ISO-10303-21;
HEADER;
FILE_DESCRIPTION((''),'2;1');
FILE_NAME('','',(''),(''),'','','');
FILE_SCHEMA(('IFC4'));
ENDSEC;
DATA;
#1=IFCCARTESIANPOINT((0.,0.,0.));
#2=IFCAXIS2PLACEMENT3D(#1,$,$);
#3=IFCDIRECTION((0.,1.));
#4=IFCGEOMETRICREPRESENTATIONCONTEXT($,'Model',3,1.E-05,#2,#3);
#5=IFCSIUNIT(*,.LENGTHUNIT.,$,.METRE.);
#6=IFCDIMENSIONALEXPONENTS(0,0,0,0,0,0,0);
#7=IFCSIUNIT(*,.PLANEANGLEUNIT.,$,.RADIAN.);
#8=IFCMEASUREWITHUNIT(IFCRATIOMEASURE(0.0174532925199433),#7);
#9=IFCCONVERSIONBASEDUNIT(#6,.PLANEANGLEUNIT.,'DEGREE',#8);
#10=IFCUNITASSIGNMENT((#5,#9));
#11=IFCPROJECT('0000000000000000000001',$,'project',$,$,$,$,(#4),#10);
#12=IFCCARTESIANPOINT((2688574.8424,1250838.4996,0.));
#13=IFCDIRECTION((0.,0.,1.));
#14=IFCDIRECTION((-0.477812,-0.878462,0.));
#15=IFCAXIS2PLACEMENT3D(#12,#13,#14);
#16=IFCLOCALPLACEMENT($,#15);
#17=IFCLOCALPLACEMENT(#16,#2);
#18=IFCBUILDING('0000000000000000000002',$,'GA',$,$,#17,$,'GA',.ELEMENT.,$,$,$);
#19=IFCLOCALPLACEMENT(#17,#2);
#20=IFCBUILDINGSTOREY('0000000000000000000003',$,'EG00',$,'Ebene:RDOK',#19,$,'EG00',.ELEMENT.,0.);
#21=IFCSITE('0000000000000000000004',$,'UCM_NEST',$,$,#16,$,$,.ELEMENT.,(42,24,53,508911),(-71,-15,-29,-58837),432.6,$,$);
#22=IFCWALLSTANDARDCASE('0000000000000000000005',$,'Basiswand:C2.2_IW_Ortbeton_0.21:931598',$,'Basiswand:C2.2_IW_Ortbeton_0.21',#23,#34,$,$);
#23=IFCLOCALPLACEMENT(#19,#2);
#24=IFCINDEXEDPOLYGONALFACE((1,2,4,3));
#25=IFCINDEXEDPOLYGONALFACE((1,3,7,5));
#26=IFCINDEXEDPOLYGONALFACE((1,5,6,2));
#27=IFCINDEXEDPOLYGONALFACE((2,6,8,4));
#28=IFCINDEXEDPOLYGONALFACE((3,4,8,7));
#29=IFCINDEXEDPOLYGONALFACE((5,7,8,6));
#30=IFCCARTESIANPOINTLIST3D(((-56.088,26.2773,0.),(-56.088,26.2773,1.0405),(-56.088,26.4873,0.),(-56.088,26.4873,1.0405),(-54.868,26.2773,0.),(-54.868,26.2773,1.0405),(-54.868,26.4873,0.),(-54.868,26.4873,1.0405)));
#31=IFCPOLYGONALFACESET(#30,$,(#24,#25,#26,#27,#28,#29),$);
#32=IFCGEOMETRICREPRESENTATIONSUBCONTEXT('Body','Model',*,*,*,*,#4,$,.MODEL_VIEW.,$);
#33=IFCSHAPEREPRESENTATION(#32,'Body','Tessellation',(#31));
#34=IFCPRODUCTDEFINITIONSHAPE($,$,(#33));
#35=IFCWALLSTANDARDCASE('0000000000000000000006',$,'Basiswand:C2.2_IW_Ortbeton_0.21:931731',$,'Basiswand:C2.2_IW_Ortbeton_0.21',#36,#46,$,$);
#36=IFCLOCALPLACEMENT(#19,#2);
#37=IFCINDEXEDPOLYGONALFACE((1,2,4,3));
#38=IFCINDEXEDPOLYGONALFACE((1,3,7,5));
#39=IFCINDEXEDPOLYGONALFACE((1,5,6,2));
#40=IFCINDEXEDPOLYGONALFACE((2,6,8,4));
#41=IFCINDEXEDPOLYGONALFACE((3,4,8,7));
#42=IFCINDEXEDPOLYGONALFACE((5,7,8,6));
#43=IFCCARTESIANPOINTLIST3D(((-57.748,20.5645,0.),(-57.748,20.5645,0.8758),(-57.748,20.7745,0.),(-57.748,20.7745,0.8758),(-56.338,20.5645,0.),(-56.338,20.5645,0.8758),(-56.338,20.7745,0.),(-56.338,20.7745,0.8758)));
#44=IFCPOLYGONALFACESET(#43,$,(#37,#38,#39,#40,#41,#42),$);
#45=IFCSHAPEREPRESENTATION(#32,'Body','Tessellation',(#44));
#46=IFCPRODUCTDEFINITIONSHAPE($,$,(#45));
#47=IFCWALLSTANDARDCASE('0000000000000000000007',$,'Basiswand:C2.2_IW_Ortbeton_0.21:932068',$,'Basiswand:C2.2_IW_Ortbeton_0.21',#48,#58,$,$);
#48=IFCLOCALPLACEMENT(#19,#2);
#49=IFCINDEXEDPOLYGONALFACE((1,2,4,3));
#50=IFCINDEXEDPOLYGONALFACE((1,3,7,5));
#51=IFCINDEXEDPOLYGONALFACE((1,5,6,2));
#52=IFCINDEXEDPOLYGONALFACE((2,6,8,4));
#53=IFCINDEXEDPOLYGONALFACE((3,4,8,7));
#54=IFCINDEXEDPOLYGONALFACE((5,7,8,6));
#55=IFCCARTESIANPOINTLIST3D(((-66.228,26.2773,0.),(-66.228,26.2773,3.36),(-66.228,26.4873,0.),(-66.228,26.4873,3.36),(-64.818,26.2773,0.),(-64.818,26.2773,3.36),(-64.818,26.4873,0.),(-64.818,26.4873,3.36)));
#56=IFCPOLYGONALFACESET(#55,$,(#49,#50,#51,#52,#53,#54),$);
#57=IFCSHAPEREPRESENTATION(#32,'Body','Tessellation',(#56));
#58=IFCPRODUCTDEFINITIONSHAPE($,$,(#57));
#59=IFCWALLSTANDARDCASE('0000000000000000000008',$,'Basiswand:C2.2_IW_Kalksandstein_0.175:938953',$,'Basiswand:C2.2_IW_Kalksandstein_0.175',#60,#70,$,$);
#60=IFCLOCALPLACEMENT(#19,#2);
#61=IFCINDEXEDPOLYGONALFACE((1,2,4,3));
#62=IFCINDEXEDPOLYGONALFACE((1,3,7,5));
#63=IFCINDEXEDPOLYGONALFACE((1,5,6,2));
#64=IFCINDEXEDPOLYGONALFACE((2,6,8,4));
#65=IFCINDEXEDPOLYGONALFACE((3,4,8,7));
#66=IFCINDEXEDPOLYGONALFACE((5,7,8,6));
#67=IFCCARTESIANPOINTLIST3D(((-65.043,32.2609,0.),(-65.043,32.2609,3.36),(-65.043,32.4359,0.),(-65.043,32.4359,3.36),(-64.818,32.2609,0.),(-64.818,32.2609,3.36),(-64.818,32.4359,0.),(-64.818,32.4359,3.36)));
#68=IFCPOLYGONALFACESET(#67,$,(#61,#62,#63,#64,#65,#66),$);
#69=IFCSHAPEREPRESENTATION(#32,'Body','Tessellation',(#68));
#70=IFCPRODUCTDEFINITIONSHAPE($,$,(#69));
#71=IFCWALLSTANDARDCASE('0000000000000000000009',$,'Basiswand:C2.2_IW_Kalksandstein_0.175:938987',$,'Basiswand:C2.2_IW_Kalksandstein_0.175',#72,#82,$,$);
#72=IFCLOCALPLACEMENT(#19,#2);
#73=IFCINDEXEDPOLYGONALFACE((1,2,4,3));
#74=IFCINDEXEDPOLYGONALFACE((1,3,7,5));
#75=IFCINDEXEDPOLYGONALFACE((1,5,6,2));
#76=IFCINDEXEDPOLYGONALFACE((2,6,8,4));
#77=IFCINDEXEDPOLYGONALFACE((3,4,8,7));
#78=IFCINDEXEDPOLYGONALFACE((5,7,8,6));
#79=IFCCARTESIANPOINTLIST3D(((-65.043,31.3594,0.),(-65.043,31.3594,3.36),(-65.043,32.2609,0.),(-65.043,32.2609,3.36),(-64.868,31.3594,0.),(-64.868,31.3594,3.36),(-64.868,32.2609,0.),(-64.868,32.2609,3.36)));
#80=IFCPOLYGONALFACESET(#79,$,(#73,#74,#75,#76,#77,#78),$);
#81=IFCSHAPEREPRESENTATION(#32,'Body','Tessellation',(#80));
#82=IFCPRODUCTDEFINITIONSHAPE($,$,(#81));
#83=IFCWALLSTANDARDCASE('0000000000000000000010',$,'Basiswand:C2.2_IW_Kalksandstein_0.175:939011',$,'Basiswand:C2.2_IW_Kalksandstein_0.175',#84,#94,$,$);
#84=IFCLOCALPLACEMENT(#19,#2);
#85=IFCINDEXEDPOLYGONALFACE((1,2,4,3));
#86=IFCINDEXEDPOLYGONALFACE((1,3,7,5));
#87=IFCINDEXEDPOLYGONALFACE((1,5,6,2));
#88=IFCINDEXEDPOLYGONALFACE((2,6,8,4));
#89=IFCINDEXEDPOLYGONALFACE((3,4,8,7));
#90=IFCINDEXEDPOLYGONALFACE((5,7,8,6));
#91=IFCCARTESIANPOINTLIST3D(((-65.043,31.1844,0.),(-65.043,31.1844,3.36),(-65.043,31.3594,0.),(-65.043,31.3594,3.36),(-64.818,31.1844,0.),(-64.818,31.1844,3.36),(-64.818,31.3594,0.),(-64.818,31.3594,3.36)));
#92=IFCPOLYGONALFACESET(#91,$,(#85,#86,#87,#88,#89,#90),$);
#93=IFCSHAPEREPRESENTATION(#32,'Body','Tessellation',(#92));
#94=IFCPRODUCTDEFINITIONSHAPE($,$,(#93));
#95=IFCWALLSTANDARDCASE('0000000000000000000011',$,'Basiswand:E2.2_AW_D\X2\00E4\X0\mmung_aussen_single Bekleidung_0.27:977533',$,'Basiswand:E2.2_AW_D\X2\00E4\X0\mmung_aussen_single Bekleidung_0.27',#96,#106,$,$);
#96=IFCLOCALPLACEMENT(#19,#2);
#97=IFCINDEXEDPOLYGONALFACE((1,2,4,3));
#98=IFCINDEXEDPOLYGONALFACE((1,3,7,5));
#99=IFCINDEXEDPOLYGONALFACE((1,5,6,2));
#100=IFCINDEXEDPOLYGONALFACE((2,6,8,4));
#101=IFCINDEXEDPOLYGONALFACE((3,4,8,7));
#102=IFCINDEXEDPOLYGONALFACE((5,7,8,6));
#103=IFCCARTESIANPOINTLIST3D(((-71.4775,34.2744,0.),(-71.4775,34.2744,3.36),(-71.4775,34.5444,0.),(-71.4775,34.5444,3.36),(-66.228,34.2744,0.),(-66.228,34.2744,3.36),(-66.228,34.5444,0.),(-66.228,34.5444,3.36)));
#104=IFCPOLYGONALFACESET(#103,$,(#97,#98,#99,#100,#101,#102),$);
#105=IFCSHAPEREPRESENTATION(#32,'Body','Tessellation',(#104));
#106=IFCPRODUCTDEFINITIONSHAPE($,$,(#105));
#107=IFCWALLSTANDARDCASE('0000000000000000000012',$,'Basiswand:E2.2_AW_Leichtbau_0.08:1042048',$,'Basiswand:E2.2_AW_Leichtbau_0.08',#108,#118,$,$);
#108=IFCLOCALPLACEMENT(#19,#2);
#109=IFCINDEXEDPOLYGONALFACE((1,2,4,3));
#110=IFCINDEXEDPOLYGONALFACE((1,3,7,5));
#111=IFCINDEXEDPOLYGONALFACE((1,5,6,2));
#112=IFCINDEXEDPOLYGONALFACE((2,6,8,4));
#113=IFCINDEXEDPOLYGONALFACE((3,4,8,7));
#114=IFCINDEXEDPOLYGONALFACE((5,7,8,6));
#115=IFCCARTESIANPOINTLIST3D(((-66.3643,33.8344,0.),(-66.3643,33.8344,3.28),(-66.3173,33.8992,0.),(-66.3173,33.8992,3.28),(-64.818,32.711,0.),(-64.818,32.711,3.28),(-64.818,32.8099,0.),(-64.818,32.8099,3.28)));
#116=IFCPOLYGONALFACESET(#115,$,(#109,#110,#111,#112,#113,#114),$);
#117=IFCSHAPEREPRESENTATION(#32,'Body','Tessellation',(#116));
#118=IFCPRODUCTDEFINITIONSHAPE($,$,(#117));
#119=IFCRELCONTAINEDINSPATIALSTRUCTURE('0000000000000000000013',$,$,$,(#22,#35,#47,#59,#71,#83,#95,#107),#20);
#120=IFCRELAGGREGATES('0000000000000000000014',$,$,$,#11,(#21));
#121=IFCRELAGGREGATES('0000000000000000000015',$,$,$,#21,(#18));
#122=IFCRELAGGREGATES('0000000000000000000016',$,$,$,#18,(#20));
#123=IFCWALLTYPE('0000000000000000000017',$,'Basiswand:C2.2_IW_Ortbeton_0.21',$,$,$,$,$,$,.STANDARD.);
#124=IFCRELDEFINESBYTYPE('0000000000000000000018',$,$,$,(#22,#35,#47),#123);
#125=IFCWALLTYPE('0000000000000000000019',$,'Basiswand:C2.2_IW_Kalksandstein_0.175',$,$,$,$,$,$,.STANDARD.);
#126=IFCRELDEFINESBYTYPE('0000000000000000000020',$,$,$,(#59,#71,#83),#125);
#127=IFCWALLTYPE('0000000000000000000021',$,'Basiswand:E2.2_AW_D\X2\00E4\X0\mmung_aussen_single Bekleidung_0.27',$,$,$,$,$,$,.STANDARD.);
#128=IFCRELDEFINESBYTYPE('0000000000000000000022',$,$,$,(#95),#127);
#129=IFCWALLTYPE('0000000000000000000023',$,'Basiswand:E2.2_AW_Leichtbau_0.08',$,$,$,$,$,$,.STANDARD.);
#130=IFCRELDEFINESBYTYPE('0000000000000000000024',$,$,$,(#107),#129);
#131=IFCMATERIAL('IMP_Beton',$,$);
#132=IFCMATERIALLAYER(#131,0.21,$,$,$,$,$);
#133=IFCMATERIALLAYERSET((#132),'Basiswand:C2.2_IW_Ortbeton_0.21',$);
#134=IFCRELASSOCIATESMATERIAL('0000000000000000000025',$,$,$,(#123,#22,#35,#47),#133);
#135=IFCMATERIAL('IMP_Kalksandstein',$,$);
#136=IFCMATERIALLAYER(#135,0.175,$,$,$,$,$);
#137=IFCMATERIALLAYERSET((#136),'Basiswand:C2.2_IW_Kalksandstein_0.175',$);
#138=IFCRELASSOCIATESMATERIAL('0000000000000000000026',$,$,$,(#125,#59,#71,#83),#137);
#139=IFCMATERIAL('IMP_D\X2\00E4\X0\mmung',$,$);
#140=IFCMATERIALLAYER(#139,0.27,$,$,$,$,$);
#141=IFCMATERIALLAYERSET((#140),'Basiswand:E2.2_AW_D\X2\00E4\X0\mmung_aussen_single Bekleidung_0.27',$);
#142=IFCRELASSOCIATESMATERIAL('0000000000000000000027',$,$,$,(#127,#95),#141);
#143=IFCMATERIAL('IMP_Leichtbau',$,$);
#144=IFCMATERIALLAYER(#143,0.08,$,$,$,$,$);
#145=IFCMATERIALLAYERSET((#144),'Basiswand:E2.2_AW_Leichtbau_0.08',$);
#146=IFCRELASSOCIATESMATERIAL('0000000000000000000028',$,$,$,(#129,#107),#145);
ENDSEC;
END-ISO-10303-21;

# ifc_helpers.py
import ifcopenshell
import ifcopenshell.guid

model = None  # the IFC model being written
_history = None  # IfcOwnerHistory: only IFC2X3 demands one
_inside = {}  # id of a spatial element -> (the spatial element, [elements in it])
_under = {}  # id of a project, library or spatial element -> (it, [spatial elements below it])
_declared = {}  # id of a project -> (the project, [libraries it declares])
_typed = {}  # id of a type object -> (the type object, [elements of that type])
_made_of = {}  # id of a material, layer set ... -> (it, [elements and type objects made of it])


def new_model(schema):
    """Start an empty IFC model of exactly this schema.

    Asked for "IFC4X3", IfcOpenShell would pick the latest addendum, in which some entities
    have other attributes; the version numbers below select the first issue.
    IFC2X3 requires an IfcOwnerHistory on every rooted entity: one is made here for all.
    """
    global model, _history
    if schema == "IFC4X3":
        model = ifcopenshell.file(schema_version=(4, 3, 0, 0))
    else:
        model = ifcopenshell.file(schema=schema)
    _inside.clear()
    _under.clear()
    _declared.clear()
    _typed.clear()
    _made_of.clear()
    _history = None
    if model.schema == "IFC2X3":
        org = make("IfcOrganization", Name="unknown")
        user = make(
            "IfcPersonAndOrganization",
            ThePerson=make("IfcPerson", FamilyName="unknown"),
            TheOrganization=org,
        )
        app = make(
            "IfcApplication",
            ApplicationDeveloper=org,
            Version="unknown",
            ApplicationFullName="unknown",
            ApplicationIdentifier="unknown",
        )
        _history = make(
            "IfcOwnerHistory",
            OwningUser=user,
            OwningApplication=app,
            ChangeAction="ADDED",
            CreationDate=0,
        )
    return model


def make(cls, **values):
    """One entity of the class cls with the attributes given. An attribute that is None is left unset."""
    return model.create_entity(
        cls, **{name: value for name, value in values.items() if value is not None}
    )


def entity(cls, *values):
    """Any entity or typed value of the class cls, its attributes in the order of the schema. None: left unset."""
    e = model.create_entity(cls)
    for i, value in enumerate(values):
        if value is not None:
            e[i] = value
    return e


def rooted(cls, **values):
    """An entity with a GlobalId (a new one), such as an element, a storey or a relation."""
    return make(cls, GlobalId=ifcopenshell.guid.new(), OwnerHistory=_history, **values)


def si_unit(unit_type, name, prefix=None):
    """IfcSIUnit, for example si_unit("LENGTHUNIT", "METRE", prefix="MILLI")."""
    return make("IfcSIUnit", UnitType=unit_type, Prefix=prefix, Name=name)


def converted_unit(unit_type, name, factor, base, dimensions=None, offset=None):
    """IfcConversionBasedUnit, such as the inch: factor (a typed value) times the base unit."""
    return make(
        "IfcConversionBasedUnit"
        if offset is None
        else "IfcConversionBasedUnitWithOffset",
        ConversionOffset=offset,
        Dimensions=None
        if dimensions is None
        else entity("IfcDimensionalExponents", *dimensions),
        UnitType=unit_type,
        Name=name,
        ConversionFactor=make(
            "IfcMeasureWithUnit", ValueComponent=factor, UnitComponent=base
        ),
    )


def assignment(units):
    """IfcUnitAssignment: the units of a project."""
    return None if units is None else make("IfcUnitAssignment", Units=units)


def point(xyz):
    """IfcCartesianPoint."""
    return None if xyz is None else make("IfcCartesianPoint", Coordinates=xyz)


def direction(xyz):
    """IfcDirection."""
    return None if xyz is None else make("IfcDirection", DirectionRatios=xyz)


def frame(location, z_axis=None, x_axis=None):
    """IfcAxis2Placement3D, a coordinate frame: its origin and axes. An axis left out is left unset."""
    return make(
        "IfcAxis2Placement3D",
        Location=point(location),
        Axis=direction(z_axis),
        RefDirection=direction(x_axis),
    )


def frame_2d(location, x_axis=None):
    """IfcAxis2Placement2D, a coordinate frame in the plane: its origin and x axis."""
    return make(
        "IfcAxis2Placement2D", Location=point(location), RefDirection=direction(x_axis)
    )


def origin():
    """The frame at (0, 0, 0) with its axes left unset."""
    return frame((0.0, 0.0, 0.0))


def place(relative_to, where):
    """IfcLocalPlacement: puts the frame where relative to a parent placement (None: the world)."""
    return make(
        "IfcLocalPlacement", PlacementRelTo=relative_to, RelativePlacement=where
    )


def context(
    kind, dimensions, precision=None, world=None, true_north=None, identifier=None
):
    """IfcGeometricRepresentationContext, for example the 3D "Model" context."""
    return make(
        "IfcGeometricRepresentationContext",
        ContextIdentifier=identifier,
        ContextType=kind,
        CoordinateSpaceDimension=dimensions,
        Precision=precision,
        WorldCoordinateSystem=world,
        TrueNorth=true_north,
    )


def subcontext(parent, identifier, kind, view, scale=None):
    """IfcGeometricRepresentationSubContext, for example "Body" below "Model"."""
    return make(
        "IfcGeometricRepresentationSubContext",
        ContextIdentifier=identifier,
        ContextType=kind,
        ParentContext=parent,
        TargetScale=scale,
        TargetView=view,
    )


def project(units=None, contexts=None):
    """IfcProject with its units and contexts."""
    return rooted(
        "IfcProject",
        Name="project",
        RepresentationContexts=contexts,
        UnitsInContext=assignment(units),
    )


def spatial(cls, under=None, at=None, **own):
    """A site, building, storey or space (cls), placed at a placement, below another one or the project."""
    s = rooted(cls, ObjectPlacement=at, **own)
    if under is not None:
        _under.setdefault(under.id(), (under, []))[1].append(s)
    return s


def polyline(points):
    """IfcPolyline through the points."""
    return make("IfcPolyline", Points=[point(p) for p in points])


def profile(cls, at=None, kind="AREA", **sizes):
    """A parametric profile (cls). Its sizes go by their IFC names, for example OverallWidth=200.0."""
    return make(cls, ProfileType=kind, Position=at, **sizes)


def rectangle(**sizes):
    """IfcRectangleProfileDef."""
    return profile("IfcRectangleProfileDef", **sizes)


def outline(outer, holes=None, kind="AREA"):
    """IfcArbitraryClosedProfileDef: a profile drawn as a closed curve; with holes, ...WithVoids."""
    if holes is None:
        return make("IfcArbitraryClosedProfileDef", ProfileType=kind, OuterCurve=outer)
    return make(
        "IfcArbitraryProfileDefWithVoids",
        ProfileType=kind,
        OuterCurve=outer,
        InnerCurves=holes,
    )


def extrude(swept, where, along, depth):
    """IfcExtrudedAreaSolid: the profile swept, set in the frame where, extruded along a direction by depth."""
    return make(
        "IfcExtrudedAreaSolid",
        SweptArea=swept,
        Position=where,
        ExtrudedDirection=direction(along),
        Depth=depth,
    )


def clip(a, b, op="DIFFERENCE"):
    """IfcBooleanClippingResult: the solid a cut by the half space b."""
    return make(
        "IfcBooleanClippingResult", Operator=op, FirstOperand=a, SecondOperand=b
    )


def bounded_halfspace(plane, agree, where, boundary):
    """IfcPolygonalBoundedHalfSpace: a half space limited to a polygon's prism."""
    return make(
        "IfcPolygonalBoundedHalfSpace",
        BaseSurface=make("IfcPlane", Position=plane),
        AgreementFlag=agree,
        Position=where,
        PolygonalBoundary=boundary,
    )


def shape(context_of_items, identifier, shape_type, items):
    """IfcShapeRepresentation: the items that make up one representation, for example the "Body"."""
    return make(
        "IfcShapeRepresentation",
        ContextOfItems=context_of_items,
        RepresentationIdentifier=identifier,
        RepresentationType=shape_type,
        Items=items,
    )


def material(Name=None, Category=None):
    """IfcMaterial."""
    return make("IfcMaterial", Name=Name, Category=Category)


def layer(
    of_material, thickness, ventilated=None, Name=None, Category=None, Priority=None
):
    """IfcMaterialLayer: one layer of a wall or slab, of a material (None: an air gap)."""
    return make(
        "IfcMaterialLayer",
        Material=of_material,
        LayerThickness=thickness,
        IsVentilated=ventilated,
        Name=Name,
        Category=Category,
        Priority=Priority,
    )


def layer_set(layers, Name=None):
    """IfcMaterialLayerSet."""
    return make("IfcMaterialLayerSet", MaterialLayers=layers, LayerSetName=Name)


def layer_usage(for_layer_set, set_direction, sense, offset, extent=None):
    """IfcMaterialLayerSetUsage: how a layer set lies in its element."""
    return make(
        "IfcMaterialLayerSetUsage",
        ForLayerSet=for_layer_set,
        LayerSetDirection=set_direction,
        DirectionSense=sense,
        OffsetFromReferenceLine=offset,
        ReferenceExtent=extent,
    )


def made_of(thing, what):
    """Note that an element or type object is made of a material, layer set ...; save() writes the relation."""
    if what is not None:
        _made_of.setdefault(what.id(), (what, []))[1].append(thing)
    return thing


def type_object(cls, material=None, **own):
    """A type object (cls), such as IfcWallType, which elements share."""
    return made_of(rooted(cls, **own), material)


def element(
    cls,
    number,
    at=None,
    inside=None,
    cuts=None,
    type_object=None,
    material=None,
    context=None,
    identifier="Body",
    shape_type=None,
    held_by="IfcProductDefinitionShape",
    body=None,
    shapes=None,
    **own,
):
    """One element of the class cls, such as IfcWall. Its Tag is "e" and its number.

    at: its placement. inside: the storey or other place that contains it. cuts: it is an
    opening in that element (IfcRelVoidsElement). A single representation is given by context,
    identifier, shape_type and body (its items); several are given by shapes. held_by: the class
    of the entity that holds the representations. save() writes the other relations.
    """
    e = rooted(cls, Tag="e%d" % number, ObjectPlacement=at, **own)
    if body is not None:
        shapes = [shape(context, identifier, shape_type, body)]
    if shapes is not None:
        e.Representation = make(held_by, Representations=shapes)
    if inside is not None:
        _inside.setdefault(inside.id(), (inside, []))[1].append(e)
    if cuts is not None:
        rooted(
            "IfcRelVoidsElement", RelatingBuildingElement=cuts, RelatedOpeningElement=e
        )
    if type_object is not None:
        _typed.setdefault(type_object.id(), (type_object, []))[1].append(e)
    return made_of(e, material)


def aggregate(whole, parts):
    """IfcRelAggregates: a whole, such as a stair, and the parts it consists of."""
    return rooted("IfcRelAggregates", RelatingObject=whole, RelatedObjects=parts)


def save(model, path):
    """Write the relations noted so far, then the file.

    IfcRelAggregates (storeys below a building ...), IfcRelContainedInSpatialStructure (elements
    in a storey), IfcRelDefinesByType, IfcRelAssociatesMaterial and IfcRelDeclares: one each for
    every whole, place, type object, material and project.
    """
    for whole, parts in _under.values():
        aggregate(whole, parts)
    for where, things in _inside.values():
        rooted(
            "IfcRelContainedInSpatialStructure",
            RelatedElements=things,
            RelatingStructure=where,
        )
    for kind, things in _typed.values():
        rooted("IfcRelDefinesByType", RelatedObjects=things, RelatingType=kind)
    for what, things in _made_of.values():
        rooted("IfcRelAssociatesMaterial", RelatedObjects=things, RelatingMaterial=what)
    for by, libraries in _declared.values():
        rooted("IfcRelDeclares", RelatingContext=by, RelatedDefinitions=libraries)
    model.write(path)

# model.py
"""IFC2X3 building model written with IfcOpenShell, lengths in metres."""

from ifc_helpers import new_model, entity, si_unit, converted_unit, direction, frame, frame_2d, origin, place, context, subcontext, project, spatial, polyline, rectangle, outline, extrude, clip, bounded_halfspace, material, layer, layer_set, layer_usage, type_object, element, save


model = new_model("IFC2X3")

# Units and contexts
model_context = context("Model", 3, precision=1e-05, world=origin(), true_north=direction((0.0, 1.0)))
body_context = subcontext(model_context, "Body", "Model", "MODEL_VIEW")
ifc_project = project(units=[si_unit("LENGTHUNIT", "METRE"), converted_unit("PLANEANGLEUNIT", "DEGREE", entity("IfcRatioMeasure", 0.0174532925199433), si_unit("PLANEANGLEUNIT", "RADIAN"), dimensions=[0, 0, 0, 0, 0, 0, 0])], contexts=[model_context])

# Site, building, storey
site_placement = place(None, frame((2688574.8424, 1250838.4996, 0.0), z_axis=(0.0, 0.0, 1.0), x_axis=(-0.477812, -0.878462, 0.0)))
site = spatial("IfcSite", under=ifc_project, at=site_placement, Name="UCM_NEST", CompositionType="ELEMENT", RefLatitude=(42, 24, 53, 508911), RefLongitude=(-71, -15, -29, -58837), RefElevation=432.6)
building_placement = place(site_placement, origin())
building = spatial("IfcBuilding", under=site, at=building_placement, Name="GA", LongName="GA", CompositionType="ELEMENT")
storey_placement = place(building_placement, origin())
storey = spatial("IfcBuildingStorey", under=building, at=storey_placement, Name="EG00", ObjectType="Ebene:RDOK", LongName="EG00", CompositionType="ELEMENT", Elevation=0.0)

# Shared definitions
ifc_material_1 = material(Name="IMP_Dämmung")
ifc_material_2 = material(Name="IMP_Beton")

# Walls
ifc_layer_1 = layer(ifc_material_2, 0.21)
ifc_layer_set_1 = layer_set([ifc_layer_1], Name="Basiswand:C2.2_IW_Ortbeton_0.21")
ifc_layer_usage_1 = layer_usage(ifc_layer_set_1, "AXIS2", "NEGATIVE", 0.105)
wall_type_1 = type_object("IfcWallType", Name="Basiswand:C2.2_IW_Ortbeton_0.21", PredefinedType="STANDARD", material=ifc_layer_set_1)
wall_1_placement = place(storey_placement, frame((-54.868, 26.3823, 0.0), z_axis=(0.0, 0.0, 1.0), x_axis=(-1.0, 0.0, 0.0)))
element("IfcWallStandardCase", 1, at=wall_1_placement, inside=storey, type_object=wall_type_1, material=ifc_layer_usage_1, Name="Basiswand:C2.2_IW_Ortbeton_0.21:931598", ObjectType="Basiswand:C2.2_IW_Ortbeton_0.21", context=body_context, shape_type="SweptSolid", body=[
    extrude(rectangle(XDim=1.22, YDim=0.21, at=frame_2d((0.61, 0.0), x_axis=(-1.0, 0.0))), origin(), (0.0, 0.0, 1.0), 1.0405),
])
ifc_layer_usage_2 = layer_usage(ifc_layer_set_1, "AXIS2", "NEGATIVE", 0.105)
wall_2_placement = place(storey_placement, frame((-56.338, 20.6695, 0.0), z_axis=(0.0, 0.0, 1.0), x_axis=(-1.0, 0.0, 0.0)))
element("IfcWallStandardCase", 2, at=wall_2_placement, inside=storey, type_object=wall_type_1, material=ifc_layer_usage_2, Name="Basiswand:C2.2_IW_Ortbeton_0.21:931731", ObjectType="Basiswand:C2.2_IW_Ortbeton_0.21", context=body_context, shape_type="SweptSolid", body=[
    extrude(rectangle(XDim=1.41, YDim=0.21, at=frame_2d((0.705, 0.0), x_axis=(-1.0, 0.0))), origin(), (0.0, 0.0, 1.0), 0.8758),
])
ifc_layer_usage_3 = layer_usage(ifc_layer_set_1, "AXIS2", "NEGATIVE", 0.105)
wall_3_placement = place(storey_placement, frame((-64.818, 26.3823, 0.0), z_axis=(0.0, 0.0, 1.0), x_axis=(-1.0, 0.0, 0.0)))
element("IfcWallStandardCase", 3, at=wall_3_placement, inside=storey, type_object=wall_type_1, material=ifc_layer_usage_3, Name="Basiswand:C2.2_IW_Ortbeton_0.21:932068", ObjectType="Basiswand:C2.2_IW_Ortbeton_0.21", context=body_context, shape_type="SweptSolid", body=[
    extrude(rectangle(XDim=1.41, YDim=0.21, at=frame_2d((0.705, 0.0), x_axis=(-1.0, 0.0))), origin(), (0.0, 0.0, 1.0), 3.36),
])
ifc_material_3 = material(Name="IMP_Kalksandstein")
ifc_layer_2 = layer(ifc_material_3, 0.175)
ifc_layer_set_2 = layer_set([ifc_layer_2], Name="Basiswand:C2.2_IW_Kalksandstein_0.175")
ifc_layer_usage_4 = layer_usage(ifc_layer_set_2, "AXIS2", "NEGATIVE", 0.0875)
wall_type_2 = type_object("IfcWallType", Name="Basiswand:C2.2_IW_Kalksandstein_0.175", PredefinedType="STANDARD", material=ifc_layer_set_2)
wall_4_placement = place(storey_placement, frame((-64.818, 32.3484, 0.0), z_axis=(0.0, 0.0, 1.0), x_axis=(-1.0, 0.0, 0.0)))
element("IfcWallStandardCase", 4, at=wall_4_placement, inside=storey, type_object=wall_type_2, material=ifc_layer_usage_4, Name="Basiswand:C2.2_IW_Kalksandstein_0.175:938953", ObjectType="Basiswand:C2.2_IW_Kalksandstein_0.175", context=body_context, shape_type="SweptSolid", body=[
    extrude(rectangle(XDim=0.225, YDim=0.175, at=frame_2d((0.1125, 0.0), x_axis=(-1.0, 0.0))), origin(), (0.0, 0.0, 1.0), 3.36),
])
ifc_layer_usage_5 = layer_usage(ifc_layer_set_2, "AXIS2", "NEGATIVE", 0.0875)
wall_5_placement = place(storey_placement, frame((-64.9555, 32.2609, 0.0), z_axis=(0.0, 0.0, 1.0), x_axis=(0.0, -1.0, 0.0)))
element("IfcWallStandardCase", 5, at=wall_5_placement, inside=storey, type_object=wall_type_2, material=ifc_layer_usage_5, Name="Basiswand:C2.2_IW_Kalksandstein_0.175:938987", ObjectType="Basiswand:C2.2_IW_Kalksandstein_0.175", context=body_context, shape_type="SweptSolid", body=[
    extrude(rectangle(XDim=0.9015, YDim=0.175, at=frame_2d((0.4507, 0.0), x_axis=(-1.0, 0.0))), origin(), (0.0, 0.0, 1.0), 3.36),
])
ifc_layer_usage_6 = layer_usage(ifc_layer_set_2, "AXIS2", "NEGATIVE", 0.0875)
wall_6_placement = place(storey_placement, frame((-65.043, 31.2719, 0.0)))
element("IfcWallStandardCase", 6, at=wall_6_placement, inside=storey, type_object=wall_type_2, material=ifc_layer_usage_6, Name="Basiswand:C2.2_IW_Kalksandstein_0.175:939011", ObjectType="Basiswand:C2.2_IW_Kalksandstein_0.175", context=body_context, shape_type="SweptSolid", body=[
    extrude(rectangle(XDim=0.225, YDim=0.175, at=frame_2d((0.1125, 0.0), x_axis=(-1.0, 0.0))), origin(), (0.0, 0.0, 1.0), 3.36),
])
ifc_layer_3 = layer(ifc_material_1, 0.27)
ifc_layer_set_3 = layer_set([ifc_layer_3], Name="Basiswand:E2.2_AW_Dämmung_aussen_single Bekleidung_0.27")
ifc_layer_usage_7 = layer_usage(ifc_layer_set_3, "AXIS2", "NEGATIVE", 0.135)
wall_type_3 = type_object("IfcWallType", Name="Basiswand:E2.2_AW_Dämmung_aussen_single Bekleidung_0.27", PredefinedType="STANDARD", material=ifc_layer_set_3)
wall_7_placement = place(storey_placement, frame((-66.228, 34.4094, 0.0), z_axis=(0.0, 0.0, 1.0), x_axis=(-1.0, 0.0, 0.0)))
element("IfcWallStandardCase", 7, at=wall_7_placement, inside=storey, type_object=wall_type_3, material=ifc_layer_usage_7, Name="Basiswand:E2.2_AW_Dämmung_aussen_single Bekleidung_0.27:977533", ObjectType="Basiswand:E2.2_AW_Dämmung_aussen_single Bekleidung_0.27", context=body_context, shape_type="SweptSolid", body=[
    extrude(rectangle(XDim=5.2494, YDim=0.27, at=frame_2d((2.6247, 0.0), x_axis=(-1.0, 0.0))), origin(), (0.0, 0.0, 1.0), 3.36),
])

# Wall
ifc_material_4 = material(Name="IMP_Leichtbau")
ifc_layer_4 = layer(ifc_material_4, 0.08)
ifc_layer_set_4 = layer_set([ifc_layer_4], Name="Basiswand:E2.2_AW_Leichtbau_0.08")
ifc_layer_usage_8 = layer_usage(ifc_layer_set_4, "AXIS2", "NEGATIVE", 0.04)
wall_type_4 = type_object("IfcWallType", Name="Basiswand:E2.2_AW_Leichtbau_0.08", PredefinedType="STANDARD", material=ifc_layer_set_4)
wall_8_placement = place(storey_placement, frame((-66.3408, 33.8668, 0.0), z_axis=(0.0, 0.0, 1.0), x_axis=(0.809017, -0.587785, 0.0)))
element("IfcWallStandardCase", 8, at=wall_8_placement, inside=storey, type_object=wall_type_4, material=ifc_layer_usage_8, Name="Basiswand:E2.2_AW_Leichtbau_0.08:1042048", ObjectType="Basiswand:E2.2_AW_Leichtbau_0.08", context=body_context, shape_type="Clipping", body=[
    clip(extrude(outline(polyline([(1.9113, -0.04), (1.8532, 0.04), (0.0, 0.04), (0.0, -0.04), (1.9113, -0.04)])), origin(), (0.0, 0.0, 1.0), 3.28), bounded_halfspace(frame((0.0, -0.04, 3.28), z_axis=(0.0, 0.0, -1.0), x_axis=(-0.809017, -0.587785, 0.0)), True, frame((0.0, -0.04, 3.28), z_axis=(0.0, 0.0, -1.0), x_axis=(-0.809017, -0.587785, 0.0)), polyline([(0.0, 0.0), (-0.047, 0.0647), (-1.5463, -1.0246), (-1.5463, -1.1234), (0.0, 0.0)]))),
])

save(model, "model.ifc")
